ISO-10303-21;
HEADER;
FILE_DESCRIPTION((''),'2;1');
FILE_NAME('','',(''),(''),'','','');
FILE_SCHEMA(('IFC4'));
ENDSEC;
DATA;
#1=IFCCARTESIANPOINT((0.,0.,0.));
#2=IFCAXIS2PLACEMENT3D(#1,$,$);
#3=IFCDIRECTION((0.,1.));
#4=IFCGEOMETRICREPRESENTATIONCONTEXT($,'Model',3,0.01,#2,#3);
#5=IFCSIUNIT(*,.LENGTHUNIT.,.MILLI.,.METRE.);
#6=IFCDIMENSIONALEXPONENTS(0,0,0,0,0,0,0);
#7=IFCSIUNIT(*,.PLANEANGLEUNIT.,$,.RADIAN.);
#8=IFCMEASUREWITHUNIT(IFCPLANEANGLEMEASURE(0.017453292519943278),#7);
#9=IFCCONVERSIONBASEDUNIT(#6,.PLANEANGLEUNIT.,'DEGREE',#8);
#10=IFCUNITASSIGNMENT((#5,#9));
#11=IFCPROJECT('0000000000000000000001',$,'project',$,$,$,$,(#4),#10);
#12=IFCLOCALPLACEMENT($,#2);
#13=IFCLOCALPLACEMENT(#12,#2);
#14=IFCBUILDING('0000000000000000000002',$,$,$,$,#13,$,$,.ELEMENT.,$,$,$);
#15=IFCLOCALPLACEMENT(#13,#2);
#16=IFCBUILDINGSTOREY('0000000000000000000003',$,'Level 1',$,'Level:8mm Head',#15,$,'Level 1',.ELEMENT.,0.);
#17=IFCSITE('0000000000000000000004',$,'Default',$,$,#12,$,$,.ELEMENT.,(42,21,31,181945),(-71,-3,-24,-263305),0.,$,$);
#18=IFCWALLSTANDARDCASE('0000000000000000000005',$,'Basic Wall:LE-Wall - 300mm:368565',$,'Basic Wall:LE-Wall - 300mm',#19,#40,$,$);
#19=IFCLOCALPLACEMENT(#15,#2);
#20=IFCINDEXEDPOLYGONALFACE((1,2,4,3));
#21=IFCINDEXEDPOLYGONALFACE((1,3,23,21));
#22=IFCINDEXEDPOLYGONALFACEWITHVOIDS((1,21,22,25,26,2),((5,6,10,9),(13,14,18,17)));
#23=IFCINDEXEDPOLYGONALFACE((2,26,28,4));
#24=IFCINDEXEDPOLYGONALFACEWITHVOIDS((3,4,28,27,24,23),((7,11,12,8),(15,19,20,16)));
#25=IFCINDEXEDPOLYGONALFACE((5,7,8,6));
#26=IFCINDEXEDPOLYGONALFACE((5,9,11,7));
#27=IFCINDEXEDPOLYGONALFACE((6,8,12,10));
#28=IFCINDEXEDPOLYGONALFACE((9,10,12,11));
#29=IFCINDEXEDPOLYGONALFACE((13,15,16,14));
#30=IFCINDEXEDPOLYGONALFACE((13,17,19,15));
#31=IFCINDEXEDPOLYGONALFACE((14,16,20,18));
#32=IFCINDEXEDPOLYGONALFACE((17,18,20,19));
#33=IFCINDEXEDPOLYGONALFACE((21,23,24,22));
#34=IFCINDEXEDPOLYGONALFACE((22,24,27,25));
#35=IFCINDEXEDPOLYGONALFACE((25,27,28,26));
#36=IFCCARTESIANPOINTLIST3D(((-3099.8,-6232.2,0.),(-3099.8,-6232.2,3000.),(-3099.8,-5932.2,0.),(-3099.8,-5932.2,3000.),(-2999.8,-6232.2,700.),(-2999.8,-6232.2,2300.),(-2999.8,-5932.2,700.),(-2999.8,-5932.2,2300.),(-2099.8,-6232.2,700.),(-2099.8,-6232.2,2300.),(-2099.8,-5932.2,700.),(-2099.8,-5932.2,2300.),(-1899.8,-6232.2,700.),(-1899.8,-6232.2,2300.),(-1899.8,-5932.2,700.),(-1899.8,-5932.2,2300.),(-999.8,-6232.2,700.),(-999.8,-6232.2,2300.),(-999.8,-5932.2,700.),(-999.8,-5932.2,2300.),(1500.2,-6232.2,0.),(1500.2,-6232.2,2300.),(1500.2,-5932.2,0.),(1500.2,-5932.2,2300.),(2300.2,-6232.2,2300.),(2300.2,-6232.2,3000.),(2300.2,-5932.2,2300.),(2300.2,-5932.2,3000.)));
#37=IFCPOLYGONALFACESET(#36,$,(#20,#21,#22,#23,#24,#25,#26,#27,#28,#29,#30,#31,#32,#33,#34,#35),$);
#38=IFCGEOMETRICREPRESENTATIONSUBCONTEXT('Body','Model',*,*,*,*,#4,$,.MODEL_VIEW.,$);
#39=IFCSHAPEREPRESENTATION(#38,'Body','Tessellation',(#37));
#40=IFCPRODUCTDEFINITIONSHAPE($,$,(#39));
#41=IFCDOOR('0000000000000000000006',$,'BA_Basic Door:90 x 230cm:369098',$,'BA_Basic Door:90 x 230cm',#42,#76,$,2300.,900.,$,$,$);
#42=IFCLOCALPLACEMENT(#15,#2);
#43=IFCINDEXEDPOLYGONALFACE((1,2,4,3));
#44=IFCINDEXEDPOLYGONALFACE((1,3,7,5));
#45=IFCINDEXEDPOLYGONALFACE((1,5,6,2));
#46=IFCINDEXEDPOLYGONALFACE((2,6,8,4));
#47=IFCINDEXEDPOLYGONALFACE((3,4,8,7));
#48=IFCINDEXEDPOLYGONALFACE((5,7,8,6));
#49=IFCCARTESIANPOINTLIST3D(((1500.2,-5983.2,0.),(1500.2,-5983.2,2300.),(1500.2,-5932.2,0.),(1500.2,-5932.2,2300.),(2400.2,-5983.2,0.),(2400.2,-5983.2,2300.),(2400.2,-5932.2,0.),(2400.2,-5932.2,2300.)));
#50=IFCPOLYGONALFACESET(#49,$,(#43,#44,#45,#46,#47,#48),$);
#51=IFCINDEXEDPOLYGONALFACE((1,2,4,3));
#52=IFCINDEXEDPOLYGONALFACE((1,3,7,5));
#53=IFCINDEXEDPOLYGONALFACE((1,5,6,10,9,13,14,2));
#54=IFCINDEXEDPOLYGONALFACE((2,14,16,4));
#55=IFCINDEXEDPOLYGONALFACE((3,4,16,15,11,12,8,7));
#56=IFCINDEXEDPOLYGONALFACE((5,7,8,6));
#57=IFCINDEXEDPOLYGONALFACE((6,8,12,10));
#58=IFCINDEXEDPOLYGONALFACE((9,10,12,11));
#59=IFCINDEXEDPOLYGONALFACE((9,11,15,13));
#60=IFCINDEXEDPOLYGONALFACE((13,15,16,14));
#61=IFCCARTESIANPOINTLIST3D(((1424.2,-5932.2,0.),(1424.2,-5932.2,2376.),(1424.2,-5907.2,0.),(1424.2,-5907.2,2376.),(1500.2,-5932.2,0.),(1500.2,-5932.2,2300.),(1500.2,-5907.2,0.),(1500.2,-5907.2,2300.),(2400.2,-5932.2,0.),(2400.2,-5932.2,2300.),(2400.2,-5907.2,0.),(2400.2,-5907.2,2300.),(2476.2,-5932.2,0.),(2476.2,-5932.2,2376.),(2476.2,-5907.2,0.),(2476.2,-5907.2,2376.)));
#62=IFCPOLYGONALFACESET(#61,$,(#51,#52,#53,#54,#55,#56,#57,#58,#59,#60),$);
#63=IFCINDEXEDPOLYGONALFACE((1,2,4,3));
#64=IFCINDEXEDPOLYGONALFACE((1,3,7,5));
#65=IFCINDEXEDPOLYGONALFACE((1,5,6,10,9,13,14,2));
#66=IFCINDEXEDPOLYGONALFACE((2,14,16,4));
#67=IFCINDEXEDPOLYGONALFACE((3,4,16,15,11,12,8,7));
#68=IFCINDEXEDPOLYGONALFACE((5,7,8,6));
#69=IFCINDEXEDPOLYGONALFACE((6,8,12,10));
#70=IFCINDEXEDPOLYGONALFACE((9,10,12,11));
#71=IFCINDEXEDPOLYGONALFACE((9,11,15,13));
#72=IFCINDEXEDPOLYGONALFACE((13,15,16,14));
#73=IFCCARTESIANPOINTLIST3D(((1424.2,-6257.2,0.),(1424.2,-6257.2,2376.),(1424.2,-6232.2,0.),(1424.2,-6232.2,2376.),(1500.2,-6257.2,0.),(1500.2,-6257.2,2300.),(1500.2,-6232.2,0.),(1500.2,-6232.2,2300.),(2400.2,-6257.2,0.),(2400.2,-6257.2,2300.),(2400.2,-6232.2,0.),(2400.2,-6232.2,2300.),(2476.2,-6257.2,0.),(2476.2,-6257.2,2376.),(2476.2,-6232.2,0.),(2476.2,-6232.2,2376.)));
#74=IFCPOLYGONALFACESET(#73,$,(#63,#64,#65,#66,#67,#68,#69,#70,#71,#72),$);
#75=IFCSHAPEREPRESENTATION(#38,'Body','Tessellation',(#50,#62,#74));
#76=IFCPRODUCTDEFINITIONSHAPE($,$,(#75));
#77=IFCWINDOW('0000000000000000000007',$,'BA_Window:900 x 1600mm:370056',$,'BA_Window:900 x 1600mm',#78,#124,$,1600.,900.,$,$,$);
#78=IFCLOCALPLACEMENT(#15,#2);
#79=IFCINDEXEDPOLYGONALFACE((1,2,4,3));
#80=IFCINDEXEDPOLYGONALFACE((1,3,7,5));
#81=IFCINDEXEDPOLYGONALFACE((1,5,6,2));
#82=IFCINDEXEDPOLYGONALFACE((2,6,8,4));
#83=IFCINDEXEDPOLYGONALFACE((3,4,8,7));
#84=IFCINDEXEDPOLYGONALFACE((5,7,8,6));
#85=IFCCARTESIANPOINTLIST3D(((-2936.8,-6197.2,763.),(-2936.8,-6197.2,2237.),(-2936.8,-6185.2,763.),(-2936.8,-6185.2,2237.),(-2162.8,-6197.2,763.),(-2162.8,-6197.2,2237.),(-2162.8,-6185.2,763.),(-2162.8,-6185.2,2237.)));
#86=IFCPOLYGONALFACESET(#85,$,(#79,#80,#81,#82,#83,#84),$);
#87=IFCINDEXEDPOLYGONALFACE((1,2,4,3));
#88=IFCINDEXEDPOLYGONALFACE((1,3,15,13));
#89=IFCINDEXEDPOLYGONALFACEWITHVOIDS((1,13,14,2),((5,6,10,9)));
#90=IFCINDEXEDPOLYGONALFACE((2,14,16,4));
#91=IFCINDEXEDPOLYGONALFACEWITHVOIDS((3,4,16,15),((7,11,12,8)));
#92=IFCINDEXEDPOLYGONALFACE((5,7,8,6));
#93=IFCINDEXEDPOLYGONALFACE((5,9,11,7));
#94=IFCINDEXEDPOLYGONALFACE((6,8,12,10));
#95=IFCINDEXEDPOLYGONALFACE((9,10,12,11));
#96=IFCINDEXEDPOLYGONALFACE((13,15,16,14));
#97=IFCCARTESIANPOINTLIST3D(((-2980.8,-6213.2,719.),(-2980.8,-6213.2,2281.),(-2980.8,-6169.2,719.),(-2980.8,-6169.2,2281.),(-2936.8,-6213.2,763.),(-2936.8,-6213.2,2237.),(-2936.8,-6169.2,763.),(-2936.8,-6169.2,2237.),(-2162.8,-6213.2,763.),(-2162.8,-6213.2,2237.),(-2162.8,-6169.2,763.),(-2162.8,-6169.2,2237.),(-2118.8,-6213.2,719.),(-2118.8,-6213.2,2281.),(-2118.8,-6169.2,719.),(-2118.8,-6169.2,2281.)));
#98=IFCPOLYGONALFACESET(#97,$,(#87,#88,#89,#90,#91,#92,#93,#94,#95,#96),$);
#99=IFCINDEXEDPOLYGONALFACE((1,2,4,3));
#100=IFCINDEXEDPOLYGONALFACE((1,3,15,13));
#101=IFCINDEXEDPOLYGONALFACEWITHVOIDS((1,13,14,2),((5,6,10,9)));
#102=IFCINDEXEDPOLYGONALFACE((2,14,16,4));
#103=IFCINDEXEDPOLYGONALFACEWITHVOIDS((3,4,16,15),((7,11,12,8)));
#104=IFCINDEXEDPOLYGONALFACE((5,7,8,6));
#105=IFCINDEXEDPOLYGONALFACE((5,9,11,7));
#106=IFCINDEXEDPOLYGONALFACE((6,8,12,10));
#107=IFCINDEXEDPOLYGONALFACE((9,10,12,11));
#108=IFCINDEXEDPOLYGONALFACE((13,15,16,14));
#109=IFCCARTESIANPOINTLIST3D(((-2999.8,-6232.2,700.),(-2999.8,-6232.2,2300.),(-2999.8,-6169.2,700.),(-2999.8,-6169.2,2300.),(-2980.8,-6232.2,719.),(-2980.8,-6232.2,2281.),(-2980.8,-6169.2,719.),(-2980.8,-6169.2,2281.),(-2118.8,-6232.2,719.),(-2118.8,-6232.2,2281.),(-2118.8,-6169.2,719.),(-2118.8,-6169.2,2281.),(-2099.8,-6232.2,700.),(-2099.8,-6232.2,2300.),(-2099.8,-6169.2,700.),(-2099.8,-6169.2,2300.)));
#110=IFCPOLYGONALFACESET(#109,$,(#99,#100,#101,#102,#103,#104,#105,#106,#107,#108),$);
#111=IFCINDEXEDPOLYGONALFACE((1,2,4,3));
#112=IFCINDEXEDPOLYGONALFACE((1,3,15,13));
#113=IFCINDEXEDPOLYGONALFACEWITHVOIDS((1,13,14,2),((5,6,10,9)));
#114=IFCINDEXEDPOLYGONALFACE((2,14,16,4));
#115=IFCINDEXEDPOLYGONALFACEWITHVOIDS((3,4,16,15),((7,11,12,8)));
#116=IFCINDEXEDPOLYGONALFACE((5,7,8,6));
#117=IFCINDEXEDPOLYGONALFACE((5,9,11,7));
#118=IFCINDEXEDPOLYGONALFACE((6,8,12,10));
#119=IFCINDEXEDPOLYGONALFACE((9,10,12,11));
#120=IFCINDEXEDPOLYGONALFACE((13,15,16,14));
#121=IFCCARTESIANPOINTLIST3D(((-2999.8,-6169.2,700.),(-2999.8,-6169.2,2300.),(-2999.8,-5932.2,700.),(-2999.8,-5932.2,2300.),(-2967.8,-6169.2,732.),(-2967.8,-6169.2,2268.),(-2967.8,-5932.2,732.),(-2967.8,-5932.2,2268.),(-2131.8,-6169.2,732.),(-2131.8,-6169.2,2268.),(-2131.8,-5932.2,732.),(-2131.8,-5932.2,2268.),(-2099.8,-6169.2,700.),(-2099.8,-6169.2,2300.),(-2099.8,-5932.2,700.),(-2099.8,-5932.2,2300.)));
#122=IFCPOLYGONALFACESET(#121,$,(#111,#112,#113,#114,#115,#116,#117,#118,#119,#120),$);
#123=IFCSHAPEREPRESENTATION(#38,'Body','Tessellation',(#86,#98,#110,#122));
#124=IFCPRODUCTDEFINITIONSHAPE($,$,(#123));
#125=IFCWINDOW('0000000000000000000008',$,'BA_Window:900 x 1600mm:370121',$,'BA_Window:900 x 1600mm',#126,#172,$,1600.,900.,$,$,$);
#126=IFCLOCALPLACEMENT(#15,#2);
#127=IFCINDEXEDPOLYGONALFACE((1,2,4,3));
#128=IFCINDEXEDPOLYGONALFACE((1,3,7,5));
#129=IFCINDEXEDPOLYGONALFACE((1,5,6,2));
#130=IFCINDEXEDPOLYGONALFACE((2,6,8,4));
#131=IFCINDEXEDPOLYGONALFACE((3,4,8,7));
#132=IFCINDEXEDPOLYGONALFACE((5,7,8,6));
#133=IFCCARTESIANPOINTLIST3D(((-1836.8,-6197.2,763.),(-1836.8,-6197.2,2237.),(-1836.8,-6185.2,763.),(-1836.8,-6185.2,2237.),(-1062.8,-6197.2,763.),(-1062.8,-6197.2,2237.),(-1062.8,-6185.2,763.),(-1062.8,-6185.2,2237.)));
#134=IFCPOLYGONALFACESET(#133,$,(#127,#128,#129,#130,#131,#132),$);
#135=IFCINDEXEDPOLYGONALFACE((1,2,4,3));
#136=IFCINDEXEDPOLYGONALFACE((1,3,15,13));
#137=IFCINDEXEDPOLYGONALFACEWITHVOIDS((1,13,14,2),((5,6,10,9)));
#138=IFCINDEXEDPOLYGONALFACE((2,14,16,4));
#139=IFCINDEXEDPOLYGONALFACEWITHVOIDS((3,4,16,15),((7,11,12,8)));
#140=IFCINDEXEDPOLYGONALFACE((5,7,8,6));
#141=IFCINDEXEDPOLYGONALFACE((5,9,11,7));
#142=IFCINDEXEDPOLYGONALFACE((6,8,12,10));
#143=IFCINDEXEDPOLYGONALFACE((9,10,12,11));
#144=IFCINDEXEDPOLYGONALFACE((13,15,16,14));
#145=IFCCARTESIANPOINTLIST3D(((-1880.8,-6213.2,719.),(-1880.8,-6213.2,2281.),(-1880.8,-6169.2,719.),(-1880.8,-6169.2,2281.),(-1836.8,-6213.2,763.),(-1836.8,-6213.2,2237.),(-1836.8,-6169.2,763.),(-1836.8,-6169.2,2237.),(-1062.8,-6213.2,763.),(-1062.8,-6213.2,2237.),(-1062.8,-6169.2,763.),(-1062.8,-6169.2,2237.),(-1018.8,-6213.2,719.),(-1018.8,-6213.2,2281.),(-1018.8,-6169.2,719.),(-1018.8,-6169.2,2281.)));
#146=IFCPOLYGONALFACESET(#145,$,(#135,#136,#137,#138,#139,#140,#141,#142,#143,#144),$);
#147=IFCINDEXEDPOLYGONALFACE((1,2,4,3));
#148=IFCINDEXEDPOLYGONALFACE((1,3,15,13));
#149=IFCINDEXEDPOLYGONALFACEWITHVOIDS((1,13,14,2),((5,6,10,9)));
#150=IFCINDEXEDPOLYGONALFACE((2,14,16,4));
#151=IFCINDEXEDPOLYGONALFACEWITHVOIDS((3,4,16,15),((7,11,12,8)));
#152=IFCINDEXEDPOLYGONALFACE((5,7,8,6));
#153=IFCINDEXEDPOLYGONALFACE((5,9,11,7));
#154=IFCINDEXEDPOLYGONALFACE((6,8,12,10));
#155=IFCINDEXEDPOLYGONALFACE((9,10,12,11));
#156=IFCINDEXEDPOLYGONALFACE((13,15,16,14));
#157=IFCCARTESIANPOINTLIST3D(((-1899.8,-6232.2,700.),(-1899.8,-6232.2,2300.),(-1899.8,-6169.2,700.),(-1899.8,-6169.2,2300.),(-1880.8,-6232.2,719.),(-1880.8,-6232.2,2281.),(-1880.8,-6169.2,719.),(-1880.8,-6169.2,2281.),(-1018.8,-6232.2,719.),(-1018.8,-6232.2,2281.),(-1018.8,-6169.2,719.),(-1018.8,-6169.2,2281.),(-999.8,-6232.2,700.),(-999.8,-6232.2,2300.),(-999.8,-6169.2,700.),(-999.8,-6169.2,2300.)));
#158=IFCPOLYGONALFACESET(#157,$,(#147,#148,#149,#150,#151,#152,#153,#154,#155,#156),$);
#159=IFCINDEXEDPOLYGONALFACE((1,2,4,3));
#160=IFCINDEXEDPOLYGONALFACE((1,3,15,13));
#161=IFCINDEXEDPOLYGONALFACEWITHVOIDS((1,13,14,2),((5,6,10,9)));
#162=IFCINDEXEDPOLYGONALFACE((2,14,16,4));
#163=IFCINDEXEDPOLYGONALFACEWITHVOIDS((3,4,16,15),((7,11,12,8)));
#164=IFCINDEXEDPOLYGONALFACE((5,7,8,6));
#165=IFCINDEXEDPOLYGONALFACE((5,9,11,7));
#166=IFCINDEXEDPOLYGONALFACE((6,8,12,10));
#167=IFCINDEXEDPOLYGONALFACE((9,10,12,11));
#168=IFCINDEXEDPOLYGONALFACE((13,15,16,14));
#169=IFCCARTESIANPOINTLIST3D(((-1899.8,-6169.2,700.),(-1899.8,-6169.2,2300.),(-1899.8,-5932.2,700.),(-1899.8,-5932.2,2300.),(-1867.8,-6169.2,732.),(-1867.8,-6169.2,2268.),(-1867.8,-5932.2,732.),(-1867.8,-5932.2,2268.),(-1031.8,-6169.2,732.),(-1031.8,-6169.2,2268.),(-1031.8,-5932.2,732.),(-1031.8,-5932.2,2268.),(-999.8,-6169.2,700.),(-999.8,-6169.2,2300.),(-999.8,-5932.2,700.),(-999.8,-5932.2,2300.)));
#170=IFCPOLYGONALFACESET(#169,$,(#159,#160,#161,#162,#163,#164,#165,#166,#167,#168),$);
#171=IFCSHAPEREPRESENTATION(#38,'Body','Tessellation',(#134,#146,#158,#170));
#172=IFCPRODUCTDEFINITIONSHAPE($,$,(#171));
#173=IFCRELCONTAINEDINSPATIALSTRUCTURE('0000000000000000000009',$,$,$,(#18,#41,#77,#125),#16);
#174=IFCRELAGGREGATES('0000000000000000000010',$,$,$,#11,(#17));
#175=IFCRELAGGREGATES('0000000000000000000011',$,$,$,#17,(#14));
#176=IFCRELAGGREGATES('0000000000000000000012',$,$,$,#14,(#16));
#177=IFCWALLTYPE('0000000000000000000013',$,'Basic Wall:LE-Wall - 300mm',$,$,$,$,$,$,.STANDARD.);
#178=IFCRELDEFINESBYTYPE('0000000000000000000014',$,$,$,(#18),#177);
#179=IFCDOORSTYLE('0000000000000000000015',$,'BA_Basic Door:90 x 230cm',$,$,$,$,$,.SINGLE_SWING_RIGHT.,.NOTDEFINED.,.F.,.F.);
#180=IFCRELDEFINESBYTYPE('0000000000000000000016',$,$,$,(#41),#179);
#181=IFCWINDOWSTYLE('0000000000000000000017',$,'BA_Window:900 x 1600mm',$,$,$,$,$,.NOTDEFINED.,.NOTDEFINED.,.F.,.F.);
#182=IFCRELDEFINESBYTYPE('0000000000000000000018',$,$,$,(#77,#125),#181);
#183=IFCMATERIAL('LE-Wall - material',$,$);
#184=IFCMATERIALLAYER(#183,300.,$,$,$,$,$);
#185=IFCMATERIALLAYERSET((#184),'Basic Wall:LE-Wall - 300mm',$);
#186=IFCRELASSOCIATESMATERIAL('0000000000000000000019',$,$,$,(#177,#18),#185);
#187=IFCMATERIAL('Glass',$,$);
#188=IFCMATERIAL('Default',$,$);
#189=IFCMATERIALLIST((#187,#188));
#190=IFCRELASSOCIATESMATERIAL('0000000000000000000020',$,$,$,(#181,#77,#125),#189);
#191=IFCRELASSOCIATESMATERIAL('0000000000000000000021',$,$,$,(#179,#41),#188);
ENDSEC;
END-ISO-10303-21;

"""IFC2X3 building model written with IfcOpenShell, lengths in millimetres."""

from ifc_helpers import new_model, entity, si_unit, converted_unit, direction, frame, frame_2d, origin, place, context, subcontext, project, spatial, polyline, rectangle, outline, extrude, clip, bounded_halfspace, source, transform, mapped, material, material_list, layer, layer_set, layer_usage, type_object, type_shapes, element, fill, save


model = new_model("IFC2X3")

# Units and contexts
model_context = context("Model", 3, precision=0.01, world=origin(), true_north=direction((0.0, 1.0)))
body_context = subcontext(model_context, "Body", "Model", "MODEL_VIEW")
ifc_project = project(units=[si_unit("LENGTHUNIT", "METRE", prefix="MILLI"), converted_unit("PLANEANGLEUNIT", "DEGREE", entity("IfcPlaneAngleMeasure", 0.017453292519943278), si_unit("PLANEANGLEUNIT", "RADIAN"), dimensions=[0, 0, 0, 0, 0, 0, 0])], contexts=[model_context])

# Site, building, storey
site_placement = place(None, origin())
site = spatial("IfcSite", under=ifc_project, at=site_placement, Name="Default", CompositionType="ELEMENT", RefLatitude=(42, 21, 31, 181945), RefLongitude=(-71, -3, -24, -263305), RefElevation=0.0)
building_placement = place(site_placement, origin())
building = spatial("IfcBuilding", under=site, at=building_placement, CompositionType="ELEMENT")
storey_placement = place(building_placement, origin())
storey = spatial("IfcBuildingStorey", under=building, at=storey_placement, Name="Level 1", ObjectType="Level:8mm Head", LongName="Level 1", CompositionType="ELEMENT", Elevation=0.0)

# Shared definitions
ifc_material_1 = material(Name="Default")

# Shared definitions
ifc_material_2 = material(Name="LE-Wall - material")
ifc_layer_1 = layer(ifc_material_2, 300.0)
ifc_layer_set_1 = layer_set([ifc_layer_1], Name="Basic Wall:LE-Wall - 300mm")
wall_type_1 = type_object("IfcWallType", Name="Basic Wall:LE-Wall - 300mm", PredefinedType="STANDARD", material=ifc_layer_set_1)

# Shared definitions
ifc_material_3 = material(Name="Glass")
ifc_material_list = material_list([ifc_material_3, ifc_material_1])
window_style = type_object("IfcWindowStyle", Name="BA_Window:900 x 1600mm", ConstructionType="NOTDEFINED", OperationType="NOTDEFINED", ParameterTakesPrecedence=False, Sizeable=False, material=ifc_material_list)
shared_shape_1 = source(origin(), body_context, "Body", "SweptSolid", [
    extrude(rectangle(XDim=12.0, YDim=774.0, at=frame_2d((0.0, 0.0), x_axis=(1.0, 0.0))), frame((450.0, 259.0, 63.0), z_axis=(0.0, 0.0, 1.0), x_axis=(0.0, -1.0, 0.0)), (0.0, 0.0, 1.0), 1474.0),
    extrude(outline(polyline([(-431.0, -781.0), (431.0, -781.0), (431.0, 781.0), (-431.0, 781.0), (-431.0, -781.0)]), holes=[polyline([(-387.0, -737.0), (-387.0, 737.0), (387.0, 737.0), (387.0, -737.0), (-387.0, -737.0)])]), frame((450.0, 237.0, 800.0), z_axis=(0.0, 1.0, 0.0), x_axis=(1.0, 0.0, 0.0)), (0.0, 0.0, 1.0), 44.0),
    extrude(outline(polyline([(-450.0, -800.0), (450.0, -800.0), (450.0, 800.0), (-450.0, 800.0), (-450.0, -800.0)]), holes=[polyline([(-431.0, -781.0), (-431.0, 781.0), (431.0, 781.0), (431.0, -781.0), (-431.0, -781.0)])]), frame((450.0, 237.0, 800.0), z_axis=(0.0, 1.0, 0.0), x_axis=(1.0, 0.0, 0.0)), (0.0, 0.0, 1.0), 63.0),
    extrude(outline(polyline([(-450.0, -800.0), (450.0, -800.0), (450.0, 800.0), (-450.0, 800.0), (-450.0, -800.0)]), holes=[polyline([(-418.0, -768.0), (-418.0, 768.0), (418.0, 768.0), (418.0, -768.0), (-418.0, -768.0)])]), frame((450.0, 0.0, 800.0), z_axis=(0.0, 1.0, 0.0), x_axis=(1.0, 0.0, 0.0)), (0.0, 0.0, 1.0), 237.0),
])
type_shapes(window_style, [shared_shape_1])

# Wall, openings, door, windows
ifc_layer_usage_1 = layer_usage(ifc_layer_set_1, "AXIS2", "NEGATIVE", 150.0)
wall_1_placement = place(storey_placement, frame((2300.2, -6082.2, 0.0), z_axis=(0.0, 0.0, 1.0), x_axis=(-1.0, 0.0, 0.0)))
wall_1 = element("IfcWallStandardCase", 1, at=wall_1_placement, inside=storey, type_object=wall_type_1, material=ifc_layer_usage_1, Name="Basic Wall:LE-Wall - 300mm:368565", ObjectType="Basic Wall:LE-Wall - 300mm", context=body_context, shape_type="Clipping", body=[
    clip(extrude(rectangle(XDim=5400.0, YDim=300.0, at=frame_2d((2700.0, 0.0), x_axis=(-1.0, 0.0))), origin(), (0.0, 0.0, 1.0), 3000.0), bounded_halfspace(frame((5400.0, -150.0, 3000.0), z_axis=(0.0, 0.0, -1.0), x_axis=(0.0, 1.0, 0.0)), True, frame((5400.0, -150.0, 3000.0)), polyline([(0.0, 0.0), (0.0, 300.0), (-5400.0, 300.0), (-5400.0, 0.0), (0.0, 0.0)]))),
])
opening_1_placement = place(wall_1_placement, frame((800.0, 150.0, 0.0)))
opening_1 = element("IfcOpeningElement", 2, at=opening_1_placement, cuts=wall_1, ObjectType="Opening", context=body_context, shape_type="SweptSolid", body=[
    extrude(rectangle(XDim=900.0, YDim=2300.0, at=frame_2d((1150.0, 450.0), x_axis=(0.0, 1.0))), frame((0.0, 0.0, 0.0), z_axis=(0.0, -1.0, 0.0), x_axis=(0.0, 0.0, 1.0)), (0.0, 0.0, 1.0), 300.0),
])
opening_2_placement = place(wall_1_placement, frame((4400.0, -150.0, 700.0)))
opening_2 = element("IfcOpeningElement", 3, at=opening_2_placement, cuts=wall_1, ObjectType="Opening", context=body_context, shape_type="SweptSolid", body=[
    extrude(rectangle(XDim=1600.0, YDim=900.0, at=frame_2d((800.0, 450.0), x_axis=(1.0, 0.0))), frame((0.0, 0.0, 0.0), z_axis=(0.0, 1.0, 0.0), x_axis=(0.0, 0.0, 1.0)), (0.0, 0.0, 1.0), 300.0),
])
opening_3_placement = place(wall_1_placement, frame((3300.0, -150.0, 700.0)))
opening_3 = element("IfcOpeningElement", 4, at=opening_3_placement, cuts=wall_1, ObjectType="Opening", context=body_context, shape_type="SweptSolid", body=[
    extrude(rectangle(XDim=1600.0, YDim=900.0, at=frame_2d((800.0, 450.0), x_axis=(1.0, 0.0))), frame((0.0, 0.0, 0.0), z_axis=(0.0, 1.0, 0.0), x_axis=(0.0, 0.0, 1.0)), (0.0, 0.0, 1.0), 300.0),
])
door_style_1 = type_object("IfcDoorStyle", Name="BA_Basic Door:90 x 230cm", ConstructionType="NOTDEFINED", OperationType="SINGLE_SWING_RIGHT", ParameterTakesPrecedence=False, Sizeable=False, material=ifc_material_1)
shared_shape_2 = source(origin(), body_context, "Body", "SweptSolid", [
    extrude(rectangle(XDim=51.0, YDim=900.0, at=frame_2d((0.0, 0.0), x_axis=(1.0, 0.0))), frame((450.0, 274.5, 0.0), z_axis=(0.0, 0.0, 1.0), x_axis=(0.0, 1.0, 0.0)), (0.0, 0.0, 1.0), 2300.0),
    extrude(outline(polyline([(-526.0, -1207.0), (526.0, -1207.0), (526.0, 1169.0), (450.0, 1169.0), (450.0, -1131.0), (-450.0, -1131.0), (-450.0, 1169.0), (-526.0, 1169.0), (-526.0, -1207.0)])), frame((450.0, 300.0, 1169.0), z_axis=(0.0, 1.0, 0.0), x_axis=(1.0, 0.0, 0.0)), (0.0, 0.0, 1.0), 25.0),
    extrude(outline(polyline([(-1207.0, -526.0), (1169.0, -526.0), (1169.0, -450.0), (-1131.0, -450.0), (-1131.0, 450.0), (1169.0, 450.0), (1169.0, 526.0), (-1207.0, 526.0), (-1207.0, -526.0)])), frame((450.0, -25.0, 1169.0), z_axis=(0.0, 1.0, 0.0), x_axis=(0.0, 0.0, -1.0)), (0.0, 0.0, 1.0), 25.0),
])
type_shapes(door_style_1, [shared_shape_2])
door_1_placement = place(opening_1_placement, frame((0.0, 0.0, 0.0), z_axis=(0.0, 0.0, 1.0), x_axis=(-1.0, 0.0, 0.0)))
door_1 = element("IfcDoor", 5, at=door_1_placement, inside=storey, type_object=door_style_1, material=ifc_material_1, Name="BA_Basic Door:90 x 230cm:369098", ObjectType="BA_Basic Door:90 x 230cm", OverallHeight=2300.0, OverallWidth=900.0, context=body_context, shape_type="MappedRepresentation", body=[
    mapped(shared_shape_2, transform((0.0, 0.0, 0.0), scale=1.0)),
])
fill(opening_1, door_1)
window_1_placement = place(opening_2_placement, origin())
window_1 = element("IfcWindow", 6, at=window_1_placement, inside=storey, type_object=window_style, material=ifc_material_list, Name="BA_Window:900 x 1600mm:370056", ObjectType="BA_Window:900 x 1600mm", OverallHeight=1600.0, OverallWidth=900.0, context=body_context, shape_type="MappedRepresentation", body=[
    mapped(shared_shape_1, transform((0.0, 0.0, 0.0), scale=1.0)),
])
fill(opening_2, window_1)
window_2_placement = place(opening_3_placement, origin())
window_2 = element("IfcWindow", 7, at=window_2_placement, inside=storey, type_object=window_style, material=ifc_material_list, Name="BA_Window:900 x 1600mm:370121", ObjectType="BA_Window:900 x 1600mm", OverallHeight=1600.0, OverallWidth=900.0, context=body_context, shape_type="MappedRepresentation", body=[
    mapped(shared_shape_1, transform((0.0, 0.0, 0.0), scale=1.0)),
])
fill(opening_3, window_2)

save(model, "model.ifc")
